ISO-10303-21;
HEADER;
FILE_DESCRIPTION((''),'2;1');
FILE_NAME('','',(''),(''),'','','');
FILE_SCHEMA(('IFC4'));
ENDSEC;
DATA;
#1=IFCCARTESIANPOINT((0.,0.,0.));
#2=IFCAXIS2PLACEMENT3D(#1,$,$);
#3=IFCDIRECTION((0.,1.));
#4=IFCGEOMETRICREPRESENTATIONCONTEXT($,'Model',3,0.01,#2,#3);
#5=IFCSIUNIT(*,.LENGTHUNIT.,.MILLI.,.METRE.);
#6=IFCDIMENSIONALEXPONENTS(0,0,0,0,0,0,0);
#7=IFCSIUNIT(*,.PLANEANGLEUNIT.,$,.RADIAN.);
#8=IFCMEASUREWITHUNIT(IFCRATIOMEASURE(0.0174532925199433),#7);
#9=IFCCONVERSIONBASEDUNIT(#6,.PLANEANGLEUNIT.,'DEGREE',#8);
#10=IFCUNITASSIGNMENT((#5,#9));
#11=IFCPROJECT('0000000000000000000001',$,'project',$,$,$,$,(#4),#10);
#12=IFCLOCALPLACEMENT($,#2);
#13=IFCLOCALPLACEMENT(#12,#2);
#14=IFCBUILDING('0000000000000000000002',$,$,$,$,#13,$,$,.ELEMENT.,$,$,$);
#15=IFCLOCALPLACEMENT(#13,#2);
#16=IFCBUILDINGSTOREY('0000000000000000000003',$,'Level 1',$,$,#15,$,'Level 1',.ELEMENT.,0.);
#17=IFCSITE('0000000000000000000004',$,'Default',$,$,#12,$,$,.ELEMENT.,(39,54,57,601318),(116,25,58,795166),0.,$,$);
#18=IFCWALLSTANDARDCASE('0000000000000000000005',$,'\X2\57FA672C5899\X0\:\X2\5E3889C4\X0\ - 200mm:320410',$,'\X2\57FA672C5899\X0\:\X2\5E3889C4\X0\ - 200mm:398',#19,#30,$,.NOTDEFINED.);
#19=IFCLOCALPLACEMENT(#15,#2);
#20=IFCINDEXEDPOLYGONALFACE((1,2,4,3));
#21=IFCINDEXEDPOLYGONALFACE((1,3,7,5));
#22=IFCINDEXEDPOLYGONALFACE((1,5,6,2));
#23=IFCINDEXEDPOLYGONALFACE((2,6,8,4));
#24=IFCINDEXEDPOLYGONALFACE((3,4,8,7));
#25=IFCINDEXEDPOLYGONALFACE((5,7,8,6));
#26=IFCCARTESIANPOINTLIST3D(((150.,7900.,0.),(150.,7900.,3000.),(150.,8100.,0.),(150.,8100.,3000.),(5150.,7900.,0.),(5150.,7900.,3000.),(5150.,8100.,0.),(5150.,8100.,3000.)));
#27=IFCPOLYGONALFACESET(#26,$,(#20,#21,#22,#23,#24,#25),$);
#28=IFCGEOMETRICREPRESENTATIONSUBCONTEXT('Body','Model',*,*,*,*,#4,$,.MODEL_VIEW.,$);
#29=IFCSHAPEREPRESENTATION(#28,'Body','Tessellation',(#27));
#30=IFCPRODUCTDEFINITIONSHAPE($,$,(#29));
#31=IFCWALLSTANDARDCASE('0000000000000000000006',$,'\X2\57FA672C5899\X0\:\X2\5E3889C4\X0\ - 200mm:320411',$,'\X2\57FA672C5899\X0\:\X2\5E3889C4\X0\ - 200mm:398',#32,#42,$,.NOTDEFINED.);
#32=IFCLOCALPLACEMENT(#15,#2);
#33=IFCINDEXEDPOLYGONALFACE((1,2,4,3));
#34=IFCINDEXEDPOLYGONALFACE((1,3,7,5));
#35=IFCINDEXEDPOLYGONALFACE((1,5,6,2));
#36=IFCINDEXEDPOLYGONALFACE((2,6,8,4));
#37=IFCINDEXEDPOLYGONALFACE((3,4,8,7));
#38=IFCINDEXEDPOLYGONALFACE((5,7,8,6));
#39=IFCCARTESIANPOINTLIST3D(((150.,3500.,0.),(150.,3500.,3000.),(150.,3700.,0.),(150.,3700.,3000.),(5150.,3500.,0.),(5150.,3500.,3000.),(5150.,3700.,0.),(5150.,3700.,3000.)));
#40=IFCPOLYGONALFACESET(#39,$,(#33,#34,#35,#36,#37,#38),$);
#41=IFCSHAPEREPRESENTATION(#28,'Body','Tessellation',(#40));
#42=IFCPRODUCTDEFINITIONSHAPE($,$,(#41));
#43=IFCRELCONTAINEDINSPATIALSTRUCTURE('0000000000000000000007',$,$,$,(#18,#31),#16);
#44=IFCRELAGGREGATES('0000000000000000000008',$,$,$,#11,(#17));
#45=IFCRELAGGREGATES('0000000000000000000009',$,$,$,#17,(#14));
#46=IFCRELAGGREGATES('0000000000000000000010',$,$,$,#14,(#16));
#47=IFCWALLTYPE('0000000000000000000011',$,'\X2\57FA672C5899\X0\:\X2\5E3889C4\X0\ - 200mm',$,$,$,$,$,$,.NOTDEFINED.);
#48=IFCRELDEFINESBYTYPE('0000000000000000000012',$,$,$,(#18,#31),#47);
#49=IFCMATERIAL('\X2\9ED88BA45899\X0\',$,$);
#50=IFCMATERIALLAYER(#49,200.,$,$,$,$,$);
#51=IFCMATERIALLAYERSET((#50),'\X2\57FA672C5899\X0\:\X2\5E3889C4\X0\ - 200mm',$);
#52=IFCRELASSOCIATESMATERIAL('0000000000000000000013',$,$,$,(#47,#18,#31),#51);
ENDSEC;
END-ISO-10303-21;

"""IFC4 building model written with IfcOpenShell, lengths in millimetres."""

from ifc_helpers import new_model, entity, si_unit, converted_unit, direction, frame, frame_2d, origin, place, context, subcontext, project, spatial, rectangle, extrude, material, layer, layer_set, layer_usage, type_object, element, save


model = new_model("IFC4")

# Units and contexts
model_context = context("Model", 3, precision=0.01, world=origin(), true_north=direction((0.0, 1.0)))
body_context = subcontext(model_context, "Body", "Model", "MODEL_VIEW")
ifc_project = project(units=[si_unit("LENGTHUNIT", "METRE", prefix="MILLI"), converted_unit("PLANEANGLEUNIT", "DEGREE", entity("IfcRatioMeasure", 0.0174532925199433), si_unit("PLANEANGLEUNIT", "RADIAN"), dimensions=[0, 0, 0, 0, 0, 0, 0])], contexts=[model_context])

# Site, building, storey
site_placement = place(None, origin())
site = spatial("IfcSite", under=ifc_project, at=site_placement, Name="Default", CompositionType="ELEMENT", RefLatitude=(39, 54, 57, 601318), RefLongitude=(116, 25, 58, 795166), RefElevation=0.0)
building_placement = place(site_placement, origin())
building = spatial("IfcBuilding", under=site, at=building_placement, CompositionType="ELEMENT")
storey_placement = place(building_placement, origin())
storey = spatial("IfcBuildingStorey", under=building, at=storey_placement, Name="Level 1", LongName="Level 1", CompositionType="ELEMENT", Elevation=0.0)

# Shared definitions
ifc_material_1 = material(Name="默认墙")
ifc_layer_1 = layer(ifc_material_1, 200.0)
ifc_layer_set_1 = layer_set([ifc_layer_1], Name="基本墙:常规 - 200mm")
wall_type = type_object("IfcWallType", Name="基本墙:常规 - 200mm", PredefinedType="NOTDEFINED", material=ifc_layer_set_1)

# Walls
ifc_layer_usage_1 = layer_usage(ifc_layer_set_1, "AXIS2", "NEGATIVE", 100.0)
wall_1_placement = place(storey_placement, frame((150.0, 8000.0, 0.0)))
element("IfcWallStandardCase", 1, at=wall_1_placement, inside=storey, type_object=wall_type, material=ifc_layer_usage_1, Name="基本墙:常规 - 200mm:320410", ObjectType="基本墙:常规 - 200mm:398", PredefinedType="NOTDEFINED", context=body_context, shape_type="SweptSolid", body=[
    extrude(rectangle(XDim=5000.0, YDim=200.0, at=frame_2d((2500.0, 0.0), x_axis=(-1.0, 0.0))), origin(), (0.0, 0.0, 1.0), 3000.0),
])
ifc_layer_usage_2 = layer_usage(ifc_layer_set_1, "AXIS2", "NEGATIVE", 100.0)
wall_2_placement = place(storey_placement, frame((150.0, 3600.0, 0.0)))
element("IfcWallStandardCase", 2, at=wall_2_placement, inside=storey, type_object=wall_type, material=ifc_layer_usage_2, Name="基本墙:常规 - 200mm:320411", ObjectType="基本墙:常规 - 200mm:398", PredefinedType="NOTDEFINED", context=body_context, shape_type="SweptSolid", body=[
    extrude(rectangle(XDim=5000.0, YDim=200.0, at=frame_2d((2500.0, 0.0), x_axis=(-1.0, 0.0))), origin(), (0.0, 0.0, 1.0), 3000.0),
])

save(model, "model.ifc")
